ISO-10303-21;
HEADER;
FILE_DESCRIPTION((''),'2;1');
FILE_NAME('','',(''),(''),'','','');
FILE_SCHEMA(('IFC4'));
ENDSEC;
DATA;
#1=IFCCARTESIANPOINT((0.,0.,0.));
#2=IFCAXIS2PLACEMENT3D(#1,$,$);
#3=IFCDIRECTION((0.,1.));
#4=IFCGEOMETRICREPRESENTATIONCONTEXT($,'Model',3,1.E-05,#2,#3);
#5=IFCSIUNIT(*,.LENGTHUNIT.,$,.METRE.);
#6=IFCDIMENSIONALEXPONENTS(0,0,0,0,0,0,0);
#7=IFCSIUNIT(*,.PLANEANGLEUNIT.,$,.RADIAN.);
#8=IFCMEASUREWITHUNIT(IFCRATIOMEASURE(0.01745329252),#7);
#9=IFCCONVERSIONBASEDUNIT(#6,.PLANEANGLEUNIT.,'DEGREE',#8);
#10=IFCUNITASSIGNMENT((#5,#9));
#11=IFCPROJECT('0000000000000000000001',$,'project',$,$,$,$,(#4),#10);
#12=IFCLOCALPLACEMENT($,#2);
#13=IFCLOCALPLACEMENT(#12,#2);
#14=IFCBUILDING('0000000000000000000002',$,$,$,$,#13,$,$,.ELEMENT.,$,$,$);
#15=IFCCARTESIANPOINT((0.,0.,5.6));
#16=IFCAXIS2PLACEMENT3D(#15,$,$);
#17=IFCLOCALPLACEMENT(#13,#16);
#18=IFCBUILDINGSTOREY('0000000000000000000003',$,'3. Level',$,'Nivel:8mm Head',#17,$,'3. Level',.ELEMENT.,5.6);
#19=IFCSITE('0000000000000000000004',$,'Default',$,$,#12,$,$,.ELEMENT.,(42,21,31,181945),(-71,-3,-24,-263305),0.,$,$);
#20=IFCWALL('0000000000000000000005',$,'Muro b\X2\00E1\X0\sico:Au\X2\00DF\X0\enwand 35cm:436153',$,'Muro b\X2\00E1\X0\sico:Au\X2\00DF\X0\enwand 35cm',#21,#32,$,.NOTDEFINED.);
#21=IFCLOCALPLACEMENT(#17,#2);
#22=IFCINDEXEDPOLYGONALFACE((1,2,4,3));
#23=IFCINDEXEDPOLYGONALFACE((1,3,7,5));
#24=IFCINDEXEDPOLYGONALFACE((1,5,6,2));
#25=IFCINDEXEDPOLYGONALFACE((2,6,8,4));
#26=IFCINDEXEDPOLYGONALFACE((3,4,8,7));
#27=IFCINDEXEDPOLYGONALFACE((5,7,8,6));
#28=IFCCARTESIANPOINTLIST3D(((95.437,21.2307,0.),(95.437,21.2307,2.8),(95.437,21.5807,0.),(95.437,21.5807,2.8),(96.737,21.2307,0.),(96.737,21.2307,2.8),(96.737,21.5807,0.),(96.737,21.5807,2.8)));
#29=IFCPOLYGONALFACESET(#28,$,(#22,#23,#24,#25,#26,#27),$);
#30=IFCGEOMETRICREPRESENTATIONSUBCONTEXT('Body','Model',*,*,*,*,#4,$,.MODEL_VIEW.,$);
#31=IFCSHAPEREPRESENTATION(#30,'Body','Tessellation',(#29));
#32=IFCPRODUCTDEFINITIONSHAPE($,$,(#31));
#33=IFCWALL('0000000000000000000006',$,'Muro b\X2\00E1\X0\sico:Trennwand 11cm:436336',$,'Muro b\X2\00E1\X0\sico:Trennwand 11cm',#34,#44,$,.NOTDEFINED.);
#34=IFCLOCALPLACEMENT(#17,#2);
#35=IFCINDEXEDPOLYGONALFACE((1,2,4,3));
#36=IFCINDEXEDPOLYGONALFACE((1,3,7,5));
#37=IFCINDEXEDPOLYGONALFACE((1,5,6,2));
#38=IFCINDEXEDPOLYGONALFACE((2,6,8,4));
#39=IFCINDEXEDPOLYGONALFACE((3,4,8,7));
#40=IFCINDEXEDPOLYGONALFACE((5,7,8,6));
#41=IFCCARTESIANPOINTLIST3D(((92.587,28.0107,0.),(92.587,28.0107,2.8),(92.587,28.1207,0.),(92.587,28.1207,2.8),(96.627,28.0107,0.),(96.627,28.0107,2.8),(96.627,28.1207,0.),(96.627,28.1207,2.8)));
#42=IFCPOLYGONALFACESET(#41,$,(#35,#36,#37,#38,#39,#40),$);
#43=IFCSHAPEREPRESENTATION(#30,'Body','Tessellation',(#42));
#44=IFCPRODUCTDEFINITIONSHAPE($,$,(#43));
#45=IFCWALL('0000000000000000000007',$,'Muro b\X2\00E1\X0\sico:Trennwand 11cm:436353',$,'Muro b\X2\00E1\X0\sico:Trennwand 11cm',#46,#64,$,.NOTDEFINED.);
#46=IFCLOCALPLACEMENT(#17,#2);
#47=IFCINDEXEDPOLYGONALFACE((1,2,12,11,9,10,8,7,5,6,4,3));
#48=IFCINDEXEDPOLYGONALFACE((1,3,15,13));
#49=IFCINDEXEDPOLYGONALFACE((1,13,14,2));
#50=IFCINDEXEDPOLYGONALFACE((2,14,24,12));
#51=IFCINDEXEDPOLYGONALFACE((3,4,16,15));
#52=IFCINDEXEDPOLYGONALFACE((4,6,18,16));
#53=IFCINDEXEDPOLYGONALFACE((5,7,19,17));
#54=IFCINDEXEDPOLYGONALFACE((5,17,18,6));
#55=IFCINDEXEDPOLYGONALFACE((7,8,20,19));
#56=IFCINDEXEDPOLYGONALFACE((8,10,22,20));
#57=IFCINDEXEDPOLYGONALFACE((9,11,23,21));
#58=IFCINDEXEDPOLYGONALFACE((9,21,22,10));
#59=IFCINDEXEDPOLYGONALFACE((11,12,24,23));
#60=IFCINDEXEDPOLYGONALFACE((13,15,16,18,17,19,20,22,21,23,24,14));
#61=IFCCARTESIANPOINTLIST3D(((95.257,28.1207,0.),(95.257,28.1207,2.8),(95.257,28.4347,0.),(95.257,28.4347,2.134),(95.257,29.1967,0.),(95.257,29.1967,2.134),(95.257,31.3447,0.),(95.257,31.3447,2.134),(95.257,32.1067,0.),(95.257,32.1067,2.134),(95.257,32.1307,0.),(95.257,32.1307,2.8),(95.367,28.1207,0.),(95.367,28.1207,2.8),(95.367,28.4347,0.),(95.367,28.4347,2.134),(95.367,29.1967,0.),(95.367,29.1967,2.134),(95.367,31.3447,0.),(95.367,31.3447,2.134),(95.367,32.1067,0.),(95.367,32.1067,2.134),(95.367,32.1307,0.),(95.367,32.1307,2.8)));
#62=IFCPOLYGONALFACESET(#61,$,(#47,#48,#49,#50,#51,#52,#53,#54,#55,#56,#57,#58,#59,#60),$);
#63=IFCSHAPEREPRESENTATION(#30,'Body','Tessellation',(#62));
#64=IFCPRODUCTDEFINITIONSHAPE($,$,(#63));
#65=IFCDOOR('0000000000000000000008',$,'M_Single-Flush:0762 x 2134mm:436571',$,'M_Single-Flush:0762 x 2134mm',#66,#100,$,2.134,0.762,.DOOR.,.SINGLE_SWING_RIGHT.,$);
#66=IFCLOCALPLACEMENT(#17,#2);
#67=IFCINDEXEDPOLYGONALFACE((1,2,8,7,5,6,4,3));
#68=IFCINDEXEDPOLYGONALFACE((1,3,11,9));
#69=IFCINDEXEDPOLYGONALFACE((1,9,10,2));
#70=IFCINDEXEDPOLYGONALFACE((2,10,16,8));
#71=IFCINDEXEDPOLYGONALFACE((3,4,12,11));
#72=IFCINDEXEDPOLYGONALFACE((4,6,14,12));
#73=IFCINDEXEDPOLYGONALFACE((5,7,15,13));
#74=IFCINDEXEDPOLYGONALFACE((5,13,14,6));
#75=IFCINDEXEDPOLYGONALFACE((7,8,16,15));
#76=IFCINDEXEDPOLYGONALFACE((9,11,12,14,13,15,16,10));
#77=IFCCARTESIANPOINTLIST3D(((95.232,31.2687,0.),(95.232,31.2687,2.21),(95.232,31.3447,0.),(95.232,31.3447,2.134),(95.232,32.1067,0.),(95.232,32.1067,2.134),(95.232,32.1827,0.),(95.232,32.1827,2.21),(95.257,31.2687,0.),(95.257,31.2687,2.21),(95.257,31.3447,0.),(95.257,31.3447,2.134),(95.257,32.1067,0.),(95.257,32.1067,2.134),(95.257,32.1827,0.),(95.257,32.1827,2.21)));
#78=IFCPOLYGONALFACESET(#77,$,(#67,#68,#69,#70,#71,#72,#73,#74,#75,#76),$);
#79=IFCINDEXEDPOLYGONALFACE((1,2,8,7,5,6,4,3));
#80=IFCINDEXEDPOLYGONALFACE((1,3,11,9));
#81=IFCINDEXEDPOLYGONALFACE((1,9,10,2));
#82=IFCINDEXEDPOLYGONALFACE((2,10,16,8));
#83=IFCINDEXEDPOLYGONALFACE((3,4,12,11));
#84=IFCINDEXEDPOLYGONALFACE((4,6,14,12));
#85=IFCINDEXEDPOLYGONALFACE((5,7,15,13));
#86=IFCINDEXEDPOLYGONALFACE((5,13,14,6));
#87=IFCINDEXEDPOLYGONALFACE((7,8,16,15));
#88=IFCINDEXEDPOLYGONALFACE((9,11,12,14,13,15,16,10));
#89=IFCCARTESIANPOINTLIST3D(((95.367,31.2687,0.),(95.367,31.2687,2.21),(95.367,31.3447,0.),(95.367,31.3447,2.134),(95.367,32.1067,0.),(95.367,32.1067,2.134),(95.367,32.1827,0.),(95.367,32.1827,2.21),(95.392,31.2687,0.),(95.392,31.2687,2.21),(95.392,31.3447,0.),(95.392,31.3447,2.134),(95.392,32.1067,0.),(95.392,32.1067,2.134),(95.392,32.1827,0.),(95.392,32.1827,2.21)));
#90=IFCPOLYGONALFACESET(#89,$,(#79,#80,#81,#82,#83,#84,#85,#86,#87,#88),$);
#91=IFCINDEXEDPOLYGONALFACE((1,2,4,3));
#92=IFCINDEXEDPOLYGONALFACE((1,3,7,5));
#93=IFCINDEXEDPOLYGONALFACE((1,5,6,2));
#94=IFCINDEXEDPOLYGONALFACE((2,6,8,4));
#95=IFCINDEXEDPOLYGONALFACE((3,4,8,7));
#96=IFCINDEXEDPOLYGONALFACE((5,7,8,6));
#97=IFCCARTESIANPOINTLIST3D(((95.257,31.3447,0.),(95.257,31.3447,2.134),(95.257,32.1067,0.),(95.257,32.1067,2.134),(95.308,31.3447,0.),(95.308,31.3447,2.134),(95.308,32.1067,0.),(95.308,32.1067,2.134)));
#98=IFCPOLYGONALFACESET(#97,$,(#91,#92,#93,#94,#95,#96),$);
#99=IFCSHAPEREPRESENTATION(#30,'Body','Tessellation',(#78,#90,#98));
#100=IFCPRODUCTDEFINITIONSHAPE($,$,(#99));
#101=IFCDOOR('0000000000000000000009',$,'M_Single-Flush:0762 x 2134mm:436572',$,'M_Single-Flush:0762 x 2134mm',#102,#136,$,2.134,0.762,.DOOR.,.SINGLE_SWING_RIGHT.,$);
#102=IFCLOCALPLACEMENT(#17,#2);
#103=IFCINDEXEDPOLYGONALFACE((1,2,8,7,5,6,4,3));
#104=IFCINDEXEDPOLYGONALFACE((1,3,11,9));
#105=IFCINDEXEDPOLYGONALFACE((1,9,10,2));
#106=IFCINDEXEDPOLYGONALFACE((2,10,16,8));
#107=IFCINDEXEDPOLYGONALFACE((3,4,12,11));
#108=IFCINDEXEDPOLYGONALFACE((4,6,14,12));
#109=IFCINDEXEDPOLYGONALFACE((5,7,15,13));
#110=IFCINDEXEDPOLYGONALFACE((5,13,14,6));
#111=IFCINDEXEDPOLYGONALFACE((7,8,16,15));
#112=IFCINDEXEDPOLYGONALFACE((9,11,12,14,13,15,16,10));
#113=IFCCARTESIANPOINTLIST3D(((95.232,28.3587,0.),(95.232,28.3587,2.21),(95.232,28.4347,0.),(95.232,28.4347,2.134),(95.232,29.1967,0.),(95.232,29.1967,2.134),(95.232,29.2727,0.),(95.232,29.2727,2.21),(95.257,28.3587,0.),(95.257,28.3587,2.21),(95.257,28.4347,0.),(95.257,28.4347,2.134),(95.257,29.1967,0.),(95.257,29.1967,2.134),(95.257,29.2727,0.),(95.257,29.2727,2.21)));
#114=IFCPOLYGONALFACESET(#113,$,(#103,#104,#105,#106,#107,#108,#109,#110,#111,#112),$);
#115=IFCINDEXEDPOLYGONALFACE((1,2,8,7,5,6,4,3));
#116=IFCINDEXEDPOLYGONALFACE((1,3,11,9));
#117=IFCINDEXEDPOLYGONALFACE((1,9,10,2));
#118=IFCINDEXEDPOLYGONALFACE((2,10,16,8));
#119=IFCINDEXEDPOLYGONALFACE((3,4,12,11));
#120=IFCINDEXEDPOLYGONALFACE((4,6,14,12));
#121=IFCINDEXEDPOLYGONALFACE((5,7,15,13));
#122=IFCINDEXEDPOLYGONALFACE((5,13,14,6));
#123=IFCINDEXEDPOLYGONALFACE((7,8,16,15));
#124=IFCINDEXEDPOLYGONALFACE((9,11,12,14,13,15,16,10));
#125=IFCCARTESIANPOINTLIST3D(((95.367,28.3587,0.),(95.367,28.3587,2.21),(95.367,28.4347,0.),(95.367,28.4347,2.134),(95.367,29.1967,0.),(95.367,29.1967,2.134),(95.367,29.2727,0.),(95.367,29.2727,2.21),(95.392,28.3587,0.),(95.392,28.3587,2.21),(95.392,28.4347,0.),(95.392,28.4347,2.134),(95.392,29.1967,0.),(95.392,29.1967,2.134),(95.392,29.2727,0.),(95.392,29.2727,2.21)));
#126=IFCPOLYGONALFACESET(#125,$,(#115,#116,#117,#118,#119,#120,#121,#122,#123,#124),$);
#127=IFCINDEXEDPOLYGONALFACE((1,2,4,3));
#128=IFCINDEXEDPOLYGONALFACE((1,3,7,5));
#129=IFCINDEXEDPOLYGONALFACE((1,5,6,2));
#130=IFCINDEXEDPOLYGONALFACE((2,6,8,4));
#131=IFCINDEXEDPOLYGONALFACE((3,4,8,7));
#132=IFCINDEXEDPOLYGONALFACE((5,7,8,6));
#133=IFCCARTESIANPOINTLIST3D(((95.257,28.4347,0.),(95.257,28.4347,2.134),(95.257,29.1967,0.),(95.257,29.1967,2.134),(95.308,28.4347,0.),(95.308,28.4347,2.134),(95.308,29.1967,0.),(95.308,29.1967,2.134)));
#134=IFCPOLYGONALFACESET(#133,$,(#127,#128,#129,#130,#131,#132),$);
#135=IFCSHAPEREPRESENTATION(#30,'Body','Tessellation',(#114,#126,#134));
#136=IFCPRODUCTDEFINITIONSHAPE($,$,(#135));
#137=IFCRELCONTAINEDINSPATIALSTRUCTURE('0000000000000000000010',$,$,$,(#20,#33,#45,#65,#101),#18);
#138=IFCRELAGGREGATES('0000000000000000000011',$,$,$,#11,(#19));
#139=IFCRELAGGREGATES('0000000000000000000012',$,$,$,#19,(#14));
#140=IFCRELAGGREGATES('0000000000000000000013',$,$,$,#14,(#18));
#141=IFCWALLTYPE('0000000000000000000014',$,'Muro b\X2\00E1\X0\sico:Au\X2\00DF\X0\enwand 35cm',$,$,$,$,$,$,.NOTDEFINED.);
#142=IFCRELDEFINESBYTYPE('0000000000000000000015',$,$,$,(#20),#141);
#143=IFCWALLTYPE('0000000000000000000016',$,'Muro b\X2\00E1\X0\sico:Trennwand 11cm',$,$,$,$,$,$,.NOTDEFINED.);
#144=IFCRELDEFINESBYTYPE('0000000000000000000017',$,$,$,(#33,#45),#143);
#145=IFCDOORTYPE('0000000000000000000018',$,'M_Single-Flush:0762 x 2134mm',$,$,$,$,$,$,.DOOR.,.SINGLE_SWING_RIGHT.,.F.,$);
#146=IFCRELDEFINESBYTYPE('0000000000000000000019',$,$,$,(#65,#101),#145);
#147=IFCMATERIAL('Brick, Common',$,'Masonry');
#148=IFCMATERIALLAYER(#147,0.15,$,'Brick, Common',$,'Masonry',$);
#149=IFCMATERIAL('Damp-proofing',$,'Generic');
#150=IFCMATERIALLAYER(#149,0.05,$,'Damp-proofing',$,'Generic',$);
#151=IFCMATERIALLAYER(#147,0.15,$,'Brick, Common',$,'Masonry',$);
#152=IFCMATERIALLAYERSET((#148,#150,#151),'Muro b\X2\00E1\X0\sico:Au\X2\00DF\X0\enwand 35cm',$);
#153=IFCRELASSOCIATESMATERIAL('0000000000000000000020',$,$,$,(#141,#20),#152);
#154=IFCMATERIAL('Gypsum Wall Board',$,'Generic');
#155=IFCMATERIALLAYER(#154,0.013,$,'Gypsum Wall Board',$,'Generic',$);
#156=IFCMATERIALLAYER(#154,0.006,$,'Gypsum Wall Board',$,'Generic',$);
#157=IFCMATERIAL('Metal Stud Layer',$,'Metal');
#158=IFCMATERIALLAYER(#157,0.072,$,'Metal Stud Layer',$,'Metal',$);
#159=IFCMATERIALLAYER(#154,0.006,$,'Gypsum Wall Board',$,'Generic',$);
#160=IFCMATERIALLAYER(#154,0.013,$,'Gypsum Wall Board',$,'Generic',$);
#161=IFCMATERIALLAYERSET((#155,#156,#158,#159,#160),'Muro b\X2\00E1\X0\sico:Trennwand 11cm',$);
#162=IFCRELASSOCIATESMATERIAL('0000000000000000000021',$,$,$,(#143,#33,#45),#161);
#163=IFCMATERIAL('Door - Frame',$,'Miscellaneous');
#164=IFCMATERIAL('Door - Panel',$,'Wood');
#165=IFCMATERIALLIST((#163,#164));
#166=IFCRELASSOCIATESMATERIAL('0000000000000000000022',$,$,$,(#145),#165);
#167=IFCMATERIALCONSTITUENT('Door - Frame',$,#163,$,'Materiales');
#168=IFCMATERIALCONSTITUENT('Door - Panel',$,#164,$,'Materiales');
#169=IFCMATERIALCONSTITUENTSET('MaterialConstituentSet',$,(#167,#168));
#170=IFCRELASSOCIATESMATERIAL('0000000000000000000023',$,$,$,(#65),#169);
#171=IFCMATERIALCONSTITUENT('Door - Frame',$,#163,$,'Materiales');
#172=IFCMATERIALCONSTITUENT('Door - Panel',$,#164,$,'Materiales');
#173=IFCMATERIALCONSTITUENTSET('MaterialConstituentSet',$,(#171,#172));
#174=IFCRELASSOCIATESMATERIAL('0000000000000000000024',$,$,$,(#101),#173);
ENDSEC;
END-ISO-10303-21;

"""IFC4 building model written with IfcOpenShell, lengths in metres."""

from ifc_helpers import new_model, entity, si_unit, converted_unit, direction, frame, frame_2d, origin, origin_2d_with_axis, place, context, subcontext, project, spatial, polyline, rectangle, outline, extrude, source, transform, mapped, material, material_list, layer, layer_set, layer_usage, constituent, constituent_set, type_object, type_shapes, element, fill, save


model = new_model("IFC4")

# Units and contexts
model_context = context("Model", 3, precision=1e-05, world=origin(), true_north=direction((0.0, 1.0)))
body_context = subcontext(model_context, "Body", "Model", "MODEL_VIEW")
ifc_project = project(units=[si_unit("LENGTHUNIT", "METRE"), converted_unit("PLANEANGLEUNIT", "DEGREE", entity("IfcRatioMeasure", 0.01745329252), si_unit("PLANEANGLEUNIT", "RADIAN"), dimensions=[0, 0, 0, 0, 0, 0, 0])], contexts=[model_context])

# Site, building, storey
site_placement = place(None, origin())
site = spatial("IfcSite", under=ifc_project, at=site_placement, Name="Default", CompositionType="ELEMENT", RefLatitude=(42, 21, 31, 181945), RefLongitude=(-71, -3, -24, -263305), RefElevation=0.0)
building_placement = place(site_placement, origin())
building = spatial("IfcBuilding", under=site, at=building_placement, CompositionType="ELEMENT")
storey_placement = place(building_placement, frame((0.0, 0.0, 5.6)))
storey = spatial("IfcBuildingStorey", under=building, at=storey_placement, Name="3. Level", ObjectType="Nivel:8mm Head", LongName="3. Level", CompositionType="ELEMENT", Elevation=5.6)

# Shared definitions
ifc_material_1 = material(Name="Brick, Common", Category="Masonry")
ifc_layer_1 = layer(ifc_material_1, 0.15, Name="Brick, Common", Category="Masonry")
ifc_material_2 = material(Name="Damp-proofing", Category="Generic")
ifc_layer_2 = layer(ifc_material_2, 0.05, Name="Damp-proofing", Category="Generic")
ifc_layer_3 = layer(ifc_material_1, 0.15, Name="Brick, Common", Category="Masonry")
ifc_layer_set_1 = layer_set([ifc_layer_1, ifc_layer_2, ifc_layer_3], Name="Muro básico:Außenwand 35cm")
wall_type_1 = type_object("IfcWallType", Name="Muro básico:Außenwand 35cm", PredefinedType="NOTDEFINED", material=ifc_layer_set_1)

# Wall
ifc_layer_usage_1 = layer_usage(ifc_layer_set_1, "AXIS2", "NEGATIVE", 0.175)
wall_1_placement = place(storey_placement, frame((95.437, 21.4057, 0.0)))
element("IfcWall", 1, at=wall_1_placement, inside=storey, type_object=wall_type_1, material=ifc_layer_usage_1, Name="Muro básico:Außenwand 35cm:436153", ObjectType="Muro básico:Außenwand 35cm", PredefinedType="NOTDEFINED", context=body_context, shape_type="SweptSolid", body=[
    extrude(rectangle(XDim=1.3, YDim=0.35, at=frame_2d((0.65, 0.0), x_axis=(-1.0, 0.0))), origin(), (0.0, 0.0, 1.0), 2.8),
])

# Wall
ifc_material_3 = material(Name="Gypsum Wall Board", Category="Generic")
ifc_layer_4 = layer(ifc_material_3, 0.013, Name="Gypsum Wall Board", Category="Generic")
ifc_layer_5 = layer(ifc_material_3, 0.006, Name="Gypsum Wall Board", Category="Generic")
ifc_material_4 = material(Name="Metal Stud Layer", Category="Metal")
ifc_layer_6 = layer(ifc_material_4, 0.072, Name="Metal Stud Layer", Category="Metal")
ifc_layer_7 = layer(ifc_material_3, 0.006, Name="Gypsum Wall Board", Category="Generic")
ifc_layer_8 = layer(ifc_material_3, 0.013, Name="Gypsum Wall Board", Category="Generic")
ifc_layer_set_2 = layer_set([ifc_layer_4, ifc_layer_5, ifc_layer_6, ifc_layer_7, ifc_layer_8], Name="Muro básico:Trennwand 11cm")
ifc_layer_usage_2 = layer_usage(ifc_layer_set_2, "AXIS2", "NEGATIVE", 0.055)
wall_type_2 = type_object("IfcWallType", Name="Muro básico:Trennwand 11cm", PredefinedType="NOTDEFINED", material=ifc_layer_set_2)
wall_2_placement = place(storey_placement, frame((92.587, 28.0657, 0.0)))
element("IfcWall", 2, at=wall_2_placement, inside=storey, type_object=wall_type_2, material=ifc_layer_usage_2, Name="Muro básico:Trennwand 11cm:436336", ObjectType="Muro básico:Trennwand 11cm", PredefinedType="NOTDEFINED", context=body_context, shape_type="SweptSolid", body=[
    extrude(rectangle(XDim=4.04, YDim=0.11, at=frame_2d((2.02, 0.0), x_axis=(-1.0, 0.0))), origin(), (0.0, 0.0, 1.0), 2.8),
])

# Wall, openings, doors
ifc_layer_usage_3 = layer_usage(ifc_layer_set_2, "AXIS2", "NEGATIVE", 0.055)
wall_3_placement = place(storey_placement, frame((95.312, 28.1207, 0.0), z_axis=(0.0, 0.0, 1.0), x_axis=(0.0, 1.0, 0.0)))
wall_3 = element("IfcWall", 3, at=wall_3_placement, inside=storey, type_object=wall_type_2, material=ifc_layer_usage_3, Name="Muro básico:Trennwand 11cm:436353", ObjectType="Muro básico:Trennwand 11cm", PredefinedType="NOTDEFINED", context=body_context, shape_type="SweptSolid", body=[
    extrude(rectangle(XDim=4.01, YDim=0.11, at=frame_2d((2.005, 0.0), x_axis=(-1.0, 0.0))), origin(), (0.0, 0.0, 1.0), 2.8),
])
opening_1_placement = place(wall_3_placement, frame((3.224, -0.055, 0.0)))
opening_1 = element("IfcOpeningElement", 4, at=opening_1_placement, cuts=wall_3, ObjectType="Opening", PredefinedType="OPENING", context=body_context, shape_type="SweptSolid", body=[
    extrude(rectangle(XDim=0.762, YDim=2.134, at=frame_2d((1.067, 0.381), x_axis=(0.0, 1.0))), frame((0.0, 0.0, 0.0), z_axis=(0.0, 1.0, 0.0), x_axis=(0.0, 0.0, 1.0)), (0.0, 0.0, 1.0), 0.11),
])
opening_2_placement = place(wall_3_placement, frame((0.314, -0.055, 0.0)))
opening_2 = element("IfcOpeningElement", 5, at=opening_2_placement, cuts=wall_3, ObjectType="Opening", PredefinedType="OPENING", context=body_context, shape_type="SweptSolid", body=[
    extrude(rectangle(XDim=0.762, YDim=2.134, at=frame_2d((1.067, 0.381), x_axis=(0.0, 1.0))), frame((0.0, 0.0, 0.0), z_axis=(0.0, 1.0, 0.0), x_axis=(0.0, 0.0, 1.0)), (0.0, 0.0, 1.0), 0.11),
])
ifc_material_5 = material(Name="Door - Frame", Category="Miscellaneous")
ifc_constituent_1 = constituent(ifc_material_5, Name="Door - Frame", Category="Materiales")
ifc_material_6 = material(Name="Door - Panel", Category="Wood")
ifc_constituent_2 = constituent(ifc_material_6, Name="Door - Panel", Category="Materiales")
ifc_constituent_set_1 = constituent_set(constituents=[ifc_constituent_1, ifc_constituent_2], Name="MaterialConstituentSet")
ifc_material_list_1 = material_list([ifc_material_5, ifc_material_6])
door_type_1 = type_object("IfcDoorType", Name="M_Single-Flush:0762 x 2134mm", OperationType="SINGLE_SWING_RIGHT", ParameterTakesPrecedence=False, PredefinedType="DOOR", material=ifc_material_list_1)
shared_shape_1 = source(origin(), body_context, "Body", "SweptSolid", [
    extrude(outline(polyline([(-0.457, -1.124), (0.457, -1.124), (0.457, 1.086), (0.381, 1.086), (0.381, -1.048), (-0.381, -1.048), (-0.381, 1.086), (-0.457, 1.086), (-0.457, -1.124)])), frame((0.381, 0.11, 1.086), z_axis=(0.0, 1.0, 0.0), x_axis=(1.0, 0.0, 0.0)), (0.0, 0.0, 1.0), 0.025),
    extrude(outline(polyline([(-1.124, -0.457), (1.086, -0.457), (1.086, -0.381), (-1.048, -0.381), (-1.048, 0.381), (1.086, 0.381), (1.086, 0.457), (-1.124, 0.457), (-1.124, -0.457)])), frame((0.381, -0.025, 1.086), z_axis=(0.0, 1.0, 0.0), x_axis=(0.0, 0.0, -1.0)), (0.0, 0.0, 1.0), 0.025),
    extrude(rectangle(XDim=0.051, YDim=0.762, at=origin_2d_with_axis()), frame((0.381, 0.0845, 0.0), z_axis=(0.0, 0.0, 1.0), x_axis=(0.0, 1.0, 0.0)), (0.0, 0.0, 1.0), 2.134),
])
type_shapes(door_type_1, [shared_shape_1])
door_1_placement = place(opening_1_placement, origin())
door_1 = element("IfcDoor", 6, at=door_1_placement, inside=storey, type_object=door_type_1, material=ifc_constituent_set_1, Name="M_Single-Flush:0762 x 2134mm:436571", ObjectType="M_Single-Flush:0762 x 2134mm", OperationType="SINGLE_SWING_RIGHT", OverallHeight=2.134, OverallWidth=0.762, PredefinedType="DOOR", context=body_context, shape_type="MappedRepresentation", body=[
    mapped(shared_shape_1, transform((0.0, 0.0, 0.0), scale=1.0)),
])
fill(opening_1, door_1)
ifc_constituent_3 = constituent(ifc_material_5, Name="Door - Frame", Category="Materiales")
ifc_constituent_4 = constituent(ifc_material_6, Name="Door - Panel", Category="Materiales")
ifc_constituent_set_2 = constituent_set(constituents=[ifc_constituent_3, ifc_constituent_4], Name="MaterialConstituentSet")
door_2_placement = place(opening_2_placement, origin())
door_2 = element("IfcDoor", 7, at=door_2_placement, inside=storey, type_object=door_type_1, material=ifc_constituent_set_2, Name="M_Single-Flush:0762 x 2134mm:436572", ObjectType="M_Single-Flush:0762 x 2134mm", OperationType="SINGLE_SWING_RIGHT", OverallHeight=2.134, OverallWidth=0.762, PredefinedType="DOOR", context=body_context, shape_type="MappedRepresentation", body=[
    mapped(shared_shape_1, transform((0.0, 0.0, 0.0), scale=1.0)),
])
fill(opening_2, door_2)

save(model, "model.ifc")
